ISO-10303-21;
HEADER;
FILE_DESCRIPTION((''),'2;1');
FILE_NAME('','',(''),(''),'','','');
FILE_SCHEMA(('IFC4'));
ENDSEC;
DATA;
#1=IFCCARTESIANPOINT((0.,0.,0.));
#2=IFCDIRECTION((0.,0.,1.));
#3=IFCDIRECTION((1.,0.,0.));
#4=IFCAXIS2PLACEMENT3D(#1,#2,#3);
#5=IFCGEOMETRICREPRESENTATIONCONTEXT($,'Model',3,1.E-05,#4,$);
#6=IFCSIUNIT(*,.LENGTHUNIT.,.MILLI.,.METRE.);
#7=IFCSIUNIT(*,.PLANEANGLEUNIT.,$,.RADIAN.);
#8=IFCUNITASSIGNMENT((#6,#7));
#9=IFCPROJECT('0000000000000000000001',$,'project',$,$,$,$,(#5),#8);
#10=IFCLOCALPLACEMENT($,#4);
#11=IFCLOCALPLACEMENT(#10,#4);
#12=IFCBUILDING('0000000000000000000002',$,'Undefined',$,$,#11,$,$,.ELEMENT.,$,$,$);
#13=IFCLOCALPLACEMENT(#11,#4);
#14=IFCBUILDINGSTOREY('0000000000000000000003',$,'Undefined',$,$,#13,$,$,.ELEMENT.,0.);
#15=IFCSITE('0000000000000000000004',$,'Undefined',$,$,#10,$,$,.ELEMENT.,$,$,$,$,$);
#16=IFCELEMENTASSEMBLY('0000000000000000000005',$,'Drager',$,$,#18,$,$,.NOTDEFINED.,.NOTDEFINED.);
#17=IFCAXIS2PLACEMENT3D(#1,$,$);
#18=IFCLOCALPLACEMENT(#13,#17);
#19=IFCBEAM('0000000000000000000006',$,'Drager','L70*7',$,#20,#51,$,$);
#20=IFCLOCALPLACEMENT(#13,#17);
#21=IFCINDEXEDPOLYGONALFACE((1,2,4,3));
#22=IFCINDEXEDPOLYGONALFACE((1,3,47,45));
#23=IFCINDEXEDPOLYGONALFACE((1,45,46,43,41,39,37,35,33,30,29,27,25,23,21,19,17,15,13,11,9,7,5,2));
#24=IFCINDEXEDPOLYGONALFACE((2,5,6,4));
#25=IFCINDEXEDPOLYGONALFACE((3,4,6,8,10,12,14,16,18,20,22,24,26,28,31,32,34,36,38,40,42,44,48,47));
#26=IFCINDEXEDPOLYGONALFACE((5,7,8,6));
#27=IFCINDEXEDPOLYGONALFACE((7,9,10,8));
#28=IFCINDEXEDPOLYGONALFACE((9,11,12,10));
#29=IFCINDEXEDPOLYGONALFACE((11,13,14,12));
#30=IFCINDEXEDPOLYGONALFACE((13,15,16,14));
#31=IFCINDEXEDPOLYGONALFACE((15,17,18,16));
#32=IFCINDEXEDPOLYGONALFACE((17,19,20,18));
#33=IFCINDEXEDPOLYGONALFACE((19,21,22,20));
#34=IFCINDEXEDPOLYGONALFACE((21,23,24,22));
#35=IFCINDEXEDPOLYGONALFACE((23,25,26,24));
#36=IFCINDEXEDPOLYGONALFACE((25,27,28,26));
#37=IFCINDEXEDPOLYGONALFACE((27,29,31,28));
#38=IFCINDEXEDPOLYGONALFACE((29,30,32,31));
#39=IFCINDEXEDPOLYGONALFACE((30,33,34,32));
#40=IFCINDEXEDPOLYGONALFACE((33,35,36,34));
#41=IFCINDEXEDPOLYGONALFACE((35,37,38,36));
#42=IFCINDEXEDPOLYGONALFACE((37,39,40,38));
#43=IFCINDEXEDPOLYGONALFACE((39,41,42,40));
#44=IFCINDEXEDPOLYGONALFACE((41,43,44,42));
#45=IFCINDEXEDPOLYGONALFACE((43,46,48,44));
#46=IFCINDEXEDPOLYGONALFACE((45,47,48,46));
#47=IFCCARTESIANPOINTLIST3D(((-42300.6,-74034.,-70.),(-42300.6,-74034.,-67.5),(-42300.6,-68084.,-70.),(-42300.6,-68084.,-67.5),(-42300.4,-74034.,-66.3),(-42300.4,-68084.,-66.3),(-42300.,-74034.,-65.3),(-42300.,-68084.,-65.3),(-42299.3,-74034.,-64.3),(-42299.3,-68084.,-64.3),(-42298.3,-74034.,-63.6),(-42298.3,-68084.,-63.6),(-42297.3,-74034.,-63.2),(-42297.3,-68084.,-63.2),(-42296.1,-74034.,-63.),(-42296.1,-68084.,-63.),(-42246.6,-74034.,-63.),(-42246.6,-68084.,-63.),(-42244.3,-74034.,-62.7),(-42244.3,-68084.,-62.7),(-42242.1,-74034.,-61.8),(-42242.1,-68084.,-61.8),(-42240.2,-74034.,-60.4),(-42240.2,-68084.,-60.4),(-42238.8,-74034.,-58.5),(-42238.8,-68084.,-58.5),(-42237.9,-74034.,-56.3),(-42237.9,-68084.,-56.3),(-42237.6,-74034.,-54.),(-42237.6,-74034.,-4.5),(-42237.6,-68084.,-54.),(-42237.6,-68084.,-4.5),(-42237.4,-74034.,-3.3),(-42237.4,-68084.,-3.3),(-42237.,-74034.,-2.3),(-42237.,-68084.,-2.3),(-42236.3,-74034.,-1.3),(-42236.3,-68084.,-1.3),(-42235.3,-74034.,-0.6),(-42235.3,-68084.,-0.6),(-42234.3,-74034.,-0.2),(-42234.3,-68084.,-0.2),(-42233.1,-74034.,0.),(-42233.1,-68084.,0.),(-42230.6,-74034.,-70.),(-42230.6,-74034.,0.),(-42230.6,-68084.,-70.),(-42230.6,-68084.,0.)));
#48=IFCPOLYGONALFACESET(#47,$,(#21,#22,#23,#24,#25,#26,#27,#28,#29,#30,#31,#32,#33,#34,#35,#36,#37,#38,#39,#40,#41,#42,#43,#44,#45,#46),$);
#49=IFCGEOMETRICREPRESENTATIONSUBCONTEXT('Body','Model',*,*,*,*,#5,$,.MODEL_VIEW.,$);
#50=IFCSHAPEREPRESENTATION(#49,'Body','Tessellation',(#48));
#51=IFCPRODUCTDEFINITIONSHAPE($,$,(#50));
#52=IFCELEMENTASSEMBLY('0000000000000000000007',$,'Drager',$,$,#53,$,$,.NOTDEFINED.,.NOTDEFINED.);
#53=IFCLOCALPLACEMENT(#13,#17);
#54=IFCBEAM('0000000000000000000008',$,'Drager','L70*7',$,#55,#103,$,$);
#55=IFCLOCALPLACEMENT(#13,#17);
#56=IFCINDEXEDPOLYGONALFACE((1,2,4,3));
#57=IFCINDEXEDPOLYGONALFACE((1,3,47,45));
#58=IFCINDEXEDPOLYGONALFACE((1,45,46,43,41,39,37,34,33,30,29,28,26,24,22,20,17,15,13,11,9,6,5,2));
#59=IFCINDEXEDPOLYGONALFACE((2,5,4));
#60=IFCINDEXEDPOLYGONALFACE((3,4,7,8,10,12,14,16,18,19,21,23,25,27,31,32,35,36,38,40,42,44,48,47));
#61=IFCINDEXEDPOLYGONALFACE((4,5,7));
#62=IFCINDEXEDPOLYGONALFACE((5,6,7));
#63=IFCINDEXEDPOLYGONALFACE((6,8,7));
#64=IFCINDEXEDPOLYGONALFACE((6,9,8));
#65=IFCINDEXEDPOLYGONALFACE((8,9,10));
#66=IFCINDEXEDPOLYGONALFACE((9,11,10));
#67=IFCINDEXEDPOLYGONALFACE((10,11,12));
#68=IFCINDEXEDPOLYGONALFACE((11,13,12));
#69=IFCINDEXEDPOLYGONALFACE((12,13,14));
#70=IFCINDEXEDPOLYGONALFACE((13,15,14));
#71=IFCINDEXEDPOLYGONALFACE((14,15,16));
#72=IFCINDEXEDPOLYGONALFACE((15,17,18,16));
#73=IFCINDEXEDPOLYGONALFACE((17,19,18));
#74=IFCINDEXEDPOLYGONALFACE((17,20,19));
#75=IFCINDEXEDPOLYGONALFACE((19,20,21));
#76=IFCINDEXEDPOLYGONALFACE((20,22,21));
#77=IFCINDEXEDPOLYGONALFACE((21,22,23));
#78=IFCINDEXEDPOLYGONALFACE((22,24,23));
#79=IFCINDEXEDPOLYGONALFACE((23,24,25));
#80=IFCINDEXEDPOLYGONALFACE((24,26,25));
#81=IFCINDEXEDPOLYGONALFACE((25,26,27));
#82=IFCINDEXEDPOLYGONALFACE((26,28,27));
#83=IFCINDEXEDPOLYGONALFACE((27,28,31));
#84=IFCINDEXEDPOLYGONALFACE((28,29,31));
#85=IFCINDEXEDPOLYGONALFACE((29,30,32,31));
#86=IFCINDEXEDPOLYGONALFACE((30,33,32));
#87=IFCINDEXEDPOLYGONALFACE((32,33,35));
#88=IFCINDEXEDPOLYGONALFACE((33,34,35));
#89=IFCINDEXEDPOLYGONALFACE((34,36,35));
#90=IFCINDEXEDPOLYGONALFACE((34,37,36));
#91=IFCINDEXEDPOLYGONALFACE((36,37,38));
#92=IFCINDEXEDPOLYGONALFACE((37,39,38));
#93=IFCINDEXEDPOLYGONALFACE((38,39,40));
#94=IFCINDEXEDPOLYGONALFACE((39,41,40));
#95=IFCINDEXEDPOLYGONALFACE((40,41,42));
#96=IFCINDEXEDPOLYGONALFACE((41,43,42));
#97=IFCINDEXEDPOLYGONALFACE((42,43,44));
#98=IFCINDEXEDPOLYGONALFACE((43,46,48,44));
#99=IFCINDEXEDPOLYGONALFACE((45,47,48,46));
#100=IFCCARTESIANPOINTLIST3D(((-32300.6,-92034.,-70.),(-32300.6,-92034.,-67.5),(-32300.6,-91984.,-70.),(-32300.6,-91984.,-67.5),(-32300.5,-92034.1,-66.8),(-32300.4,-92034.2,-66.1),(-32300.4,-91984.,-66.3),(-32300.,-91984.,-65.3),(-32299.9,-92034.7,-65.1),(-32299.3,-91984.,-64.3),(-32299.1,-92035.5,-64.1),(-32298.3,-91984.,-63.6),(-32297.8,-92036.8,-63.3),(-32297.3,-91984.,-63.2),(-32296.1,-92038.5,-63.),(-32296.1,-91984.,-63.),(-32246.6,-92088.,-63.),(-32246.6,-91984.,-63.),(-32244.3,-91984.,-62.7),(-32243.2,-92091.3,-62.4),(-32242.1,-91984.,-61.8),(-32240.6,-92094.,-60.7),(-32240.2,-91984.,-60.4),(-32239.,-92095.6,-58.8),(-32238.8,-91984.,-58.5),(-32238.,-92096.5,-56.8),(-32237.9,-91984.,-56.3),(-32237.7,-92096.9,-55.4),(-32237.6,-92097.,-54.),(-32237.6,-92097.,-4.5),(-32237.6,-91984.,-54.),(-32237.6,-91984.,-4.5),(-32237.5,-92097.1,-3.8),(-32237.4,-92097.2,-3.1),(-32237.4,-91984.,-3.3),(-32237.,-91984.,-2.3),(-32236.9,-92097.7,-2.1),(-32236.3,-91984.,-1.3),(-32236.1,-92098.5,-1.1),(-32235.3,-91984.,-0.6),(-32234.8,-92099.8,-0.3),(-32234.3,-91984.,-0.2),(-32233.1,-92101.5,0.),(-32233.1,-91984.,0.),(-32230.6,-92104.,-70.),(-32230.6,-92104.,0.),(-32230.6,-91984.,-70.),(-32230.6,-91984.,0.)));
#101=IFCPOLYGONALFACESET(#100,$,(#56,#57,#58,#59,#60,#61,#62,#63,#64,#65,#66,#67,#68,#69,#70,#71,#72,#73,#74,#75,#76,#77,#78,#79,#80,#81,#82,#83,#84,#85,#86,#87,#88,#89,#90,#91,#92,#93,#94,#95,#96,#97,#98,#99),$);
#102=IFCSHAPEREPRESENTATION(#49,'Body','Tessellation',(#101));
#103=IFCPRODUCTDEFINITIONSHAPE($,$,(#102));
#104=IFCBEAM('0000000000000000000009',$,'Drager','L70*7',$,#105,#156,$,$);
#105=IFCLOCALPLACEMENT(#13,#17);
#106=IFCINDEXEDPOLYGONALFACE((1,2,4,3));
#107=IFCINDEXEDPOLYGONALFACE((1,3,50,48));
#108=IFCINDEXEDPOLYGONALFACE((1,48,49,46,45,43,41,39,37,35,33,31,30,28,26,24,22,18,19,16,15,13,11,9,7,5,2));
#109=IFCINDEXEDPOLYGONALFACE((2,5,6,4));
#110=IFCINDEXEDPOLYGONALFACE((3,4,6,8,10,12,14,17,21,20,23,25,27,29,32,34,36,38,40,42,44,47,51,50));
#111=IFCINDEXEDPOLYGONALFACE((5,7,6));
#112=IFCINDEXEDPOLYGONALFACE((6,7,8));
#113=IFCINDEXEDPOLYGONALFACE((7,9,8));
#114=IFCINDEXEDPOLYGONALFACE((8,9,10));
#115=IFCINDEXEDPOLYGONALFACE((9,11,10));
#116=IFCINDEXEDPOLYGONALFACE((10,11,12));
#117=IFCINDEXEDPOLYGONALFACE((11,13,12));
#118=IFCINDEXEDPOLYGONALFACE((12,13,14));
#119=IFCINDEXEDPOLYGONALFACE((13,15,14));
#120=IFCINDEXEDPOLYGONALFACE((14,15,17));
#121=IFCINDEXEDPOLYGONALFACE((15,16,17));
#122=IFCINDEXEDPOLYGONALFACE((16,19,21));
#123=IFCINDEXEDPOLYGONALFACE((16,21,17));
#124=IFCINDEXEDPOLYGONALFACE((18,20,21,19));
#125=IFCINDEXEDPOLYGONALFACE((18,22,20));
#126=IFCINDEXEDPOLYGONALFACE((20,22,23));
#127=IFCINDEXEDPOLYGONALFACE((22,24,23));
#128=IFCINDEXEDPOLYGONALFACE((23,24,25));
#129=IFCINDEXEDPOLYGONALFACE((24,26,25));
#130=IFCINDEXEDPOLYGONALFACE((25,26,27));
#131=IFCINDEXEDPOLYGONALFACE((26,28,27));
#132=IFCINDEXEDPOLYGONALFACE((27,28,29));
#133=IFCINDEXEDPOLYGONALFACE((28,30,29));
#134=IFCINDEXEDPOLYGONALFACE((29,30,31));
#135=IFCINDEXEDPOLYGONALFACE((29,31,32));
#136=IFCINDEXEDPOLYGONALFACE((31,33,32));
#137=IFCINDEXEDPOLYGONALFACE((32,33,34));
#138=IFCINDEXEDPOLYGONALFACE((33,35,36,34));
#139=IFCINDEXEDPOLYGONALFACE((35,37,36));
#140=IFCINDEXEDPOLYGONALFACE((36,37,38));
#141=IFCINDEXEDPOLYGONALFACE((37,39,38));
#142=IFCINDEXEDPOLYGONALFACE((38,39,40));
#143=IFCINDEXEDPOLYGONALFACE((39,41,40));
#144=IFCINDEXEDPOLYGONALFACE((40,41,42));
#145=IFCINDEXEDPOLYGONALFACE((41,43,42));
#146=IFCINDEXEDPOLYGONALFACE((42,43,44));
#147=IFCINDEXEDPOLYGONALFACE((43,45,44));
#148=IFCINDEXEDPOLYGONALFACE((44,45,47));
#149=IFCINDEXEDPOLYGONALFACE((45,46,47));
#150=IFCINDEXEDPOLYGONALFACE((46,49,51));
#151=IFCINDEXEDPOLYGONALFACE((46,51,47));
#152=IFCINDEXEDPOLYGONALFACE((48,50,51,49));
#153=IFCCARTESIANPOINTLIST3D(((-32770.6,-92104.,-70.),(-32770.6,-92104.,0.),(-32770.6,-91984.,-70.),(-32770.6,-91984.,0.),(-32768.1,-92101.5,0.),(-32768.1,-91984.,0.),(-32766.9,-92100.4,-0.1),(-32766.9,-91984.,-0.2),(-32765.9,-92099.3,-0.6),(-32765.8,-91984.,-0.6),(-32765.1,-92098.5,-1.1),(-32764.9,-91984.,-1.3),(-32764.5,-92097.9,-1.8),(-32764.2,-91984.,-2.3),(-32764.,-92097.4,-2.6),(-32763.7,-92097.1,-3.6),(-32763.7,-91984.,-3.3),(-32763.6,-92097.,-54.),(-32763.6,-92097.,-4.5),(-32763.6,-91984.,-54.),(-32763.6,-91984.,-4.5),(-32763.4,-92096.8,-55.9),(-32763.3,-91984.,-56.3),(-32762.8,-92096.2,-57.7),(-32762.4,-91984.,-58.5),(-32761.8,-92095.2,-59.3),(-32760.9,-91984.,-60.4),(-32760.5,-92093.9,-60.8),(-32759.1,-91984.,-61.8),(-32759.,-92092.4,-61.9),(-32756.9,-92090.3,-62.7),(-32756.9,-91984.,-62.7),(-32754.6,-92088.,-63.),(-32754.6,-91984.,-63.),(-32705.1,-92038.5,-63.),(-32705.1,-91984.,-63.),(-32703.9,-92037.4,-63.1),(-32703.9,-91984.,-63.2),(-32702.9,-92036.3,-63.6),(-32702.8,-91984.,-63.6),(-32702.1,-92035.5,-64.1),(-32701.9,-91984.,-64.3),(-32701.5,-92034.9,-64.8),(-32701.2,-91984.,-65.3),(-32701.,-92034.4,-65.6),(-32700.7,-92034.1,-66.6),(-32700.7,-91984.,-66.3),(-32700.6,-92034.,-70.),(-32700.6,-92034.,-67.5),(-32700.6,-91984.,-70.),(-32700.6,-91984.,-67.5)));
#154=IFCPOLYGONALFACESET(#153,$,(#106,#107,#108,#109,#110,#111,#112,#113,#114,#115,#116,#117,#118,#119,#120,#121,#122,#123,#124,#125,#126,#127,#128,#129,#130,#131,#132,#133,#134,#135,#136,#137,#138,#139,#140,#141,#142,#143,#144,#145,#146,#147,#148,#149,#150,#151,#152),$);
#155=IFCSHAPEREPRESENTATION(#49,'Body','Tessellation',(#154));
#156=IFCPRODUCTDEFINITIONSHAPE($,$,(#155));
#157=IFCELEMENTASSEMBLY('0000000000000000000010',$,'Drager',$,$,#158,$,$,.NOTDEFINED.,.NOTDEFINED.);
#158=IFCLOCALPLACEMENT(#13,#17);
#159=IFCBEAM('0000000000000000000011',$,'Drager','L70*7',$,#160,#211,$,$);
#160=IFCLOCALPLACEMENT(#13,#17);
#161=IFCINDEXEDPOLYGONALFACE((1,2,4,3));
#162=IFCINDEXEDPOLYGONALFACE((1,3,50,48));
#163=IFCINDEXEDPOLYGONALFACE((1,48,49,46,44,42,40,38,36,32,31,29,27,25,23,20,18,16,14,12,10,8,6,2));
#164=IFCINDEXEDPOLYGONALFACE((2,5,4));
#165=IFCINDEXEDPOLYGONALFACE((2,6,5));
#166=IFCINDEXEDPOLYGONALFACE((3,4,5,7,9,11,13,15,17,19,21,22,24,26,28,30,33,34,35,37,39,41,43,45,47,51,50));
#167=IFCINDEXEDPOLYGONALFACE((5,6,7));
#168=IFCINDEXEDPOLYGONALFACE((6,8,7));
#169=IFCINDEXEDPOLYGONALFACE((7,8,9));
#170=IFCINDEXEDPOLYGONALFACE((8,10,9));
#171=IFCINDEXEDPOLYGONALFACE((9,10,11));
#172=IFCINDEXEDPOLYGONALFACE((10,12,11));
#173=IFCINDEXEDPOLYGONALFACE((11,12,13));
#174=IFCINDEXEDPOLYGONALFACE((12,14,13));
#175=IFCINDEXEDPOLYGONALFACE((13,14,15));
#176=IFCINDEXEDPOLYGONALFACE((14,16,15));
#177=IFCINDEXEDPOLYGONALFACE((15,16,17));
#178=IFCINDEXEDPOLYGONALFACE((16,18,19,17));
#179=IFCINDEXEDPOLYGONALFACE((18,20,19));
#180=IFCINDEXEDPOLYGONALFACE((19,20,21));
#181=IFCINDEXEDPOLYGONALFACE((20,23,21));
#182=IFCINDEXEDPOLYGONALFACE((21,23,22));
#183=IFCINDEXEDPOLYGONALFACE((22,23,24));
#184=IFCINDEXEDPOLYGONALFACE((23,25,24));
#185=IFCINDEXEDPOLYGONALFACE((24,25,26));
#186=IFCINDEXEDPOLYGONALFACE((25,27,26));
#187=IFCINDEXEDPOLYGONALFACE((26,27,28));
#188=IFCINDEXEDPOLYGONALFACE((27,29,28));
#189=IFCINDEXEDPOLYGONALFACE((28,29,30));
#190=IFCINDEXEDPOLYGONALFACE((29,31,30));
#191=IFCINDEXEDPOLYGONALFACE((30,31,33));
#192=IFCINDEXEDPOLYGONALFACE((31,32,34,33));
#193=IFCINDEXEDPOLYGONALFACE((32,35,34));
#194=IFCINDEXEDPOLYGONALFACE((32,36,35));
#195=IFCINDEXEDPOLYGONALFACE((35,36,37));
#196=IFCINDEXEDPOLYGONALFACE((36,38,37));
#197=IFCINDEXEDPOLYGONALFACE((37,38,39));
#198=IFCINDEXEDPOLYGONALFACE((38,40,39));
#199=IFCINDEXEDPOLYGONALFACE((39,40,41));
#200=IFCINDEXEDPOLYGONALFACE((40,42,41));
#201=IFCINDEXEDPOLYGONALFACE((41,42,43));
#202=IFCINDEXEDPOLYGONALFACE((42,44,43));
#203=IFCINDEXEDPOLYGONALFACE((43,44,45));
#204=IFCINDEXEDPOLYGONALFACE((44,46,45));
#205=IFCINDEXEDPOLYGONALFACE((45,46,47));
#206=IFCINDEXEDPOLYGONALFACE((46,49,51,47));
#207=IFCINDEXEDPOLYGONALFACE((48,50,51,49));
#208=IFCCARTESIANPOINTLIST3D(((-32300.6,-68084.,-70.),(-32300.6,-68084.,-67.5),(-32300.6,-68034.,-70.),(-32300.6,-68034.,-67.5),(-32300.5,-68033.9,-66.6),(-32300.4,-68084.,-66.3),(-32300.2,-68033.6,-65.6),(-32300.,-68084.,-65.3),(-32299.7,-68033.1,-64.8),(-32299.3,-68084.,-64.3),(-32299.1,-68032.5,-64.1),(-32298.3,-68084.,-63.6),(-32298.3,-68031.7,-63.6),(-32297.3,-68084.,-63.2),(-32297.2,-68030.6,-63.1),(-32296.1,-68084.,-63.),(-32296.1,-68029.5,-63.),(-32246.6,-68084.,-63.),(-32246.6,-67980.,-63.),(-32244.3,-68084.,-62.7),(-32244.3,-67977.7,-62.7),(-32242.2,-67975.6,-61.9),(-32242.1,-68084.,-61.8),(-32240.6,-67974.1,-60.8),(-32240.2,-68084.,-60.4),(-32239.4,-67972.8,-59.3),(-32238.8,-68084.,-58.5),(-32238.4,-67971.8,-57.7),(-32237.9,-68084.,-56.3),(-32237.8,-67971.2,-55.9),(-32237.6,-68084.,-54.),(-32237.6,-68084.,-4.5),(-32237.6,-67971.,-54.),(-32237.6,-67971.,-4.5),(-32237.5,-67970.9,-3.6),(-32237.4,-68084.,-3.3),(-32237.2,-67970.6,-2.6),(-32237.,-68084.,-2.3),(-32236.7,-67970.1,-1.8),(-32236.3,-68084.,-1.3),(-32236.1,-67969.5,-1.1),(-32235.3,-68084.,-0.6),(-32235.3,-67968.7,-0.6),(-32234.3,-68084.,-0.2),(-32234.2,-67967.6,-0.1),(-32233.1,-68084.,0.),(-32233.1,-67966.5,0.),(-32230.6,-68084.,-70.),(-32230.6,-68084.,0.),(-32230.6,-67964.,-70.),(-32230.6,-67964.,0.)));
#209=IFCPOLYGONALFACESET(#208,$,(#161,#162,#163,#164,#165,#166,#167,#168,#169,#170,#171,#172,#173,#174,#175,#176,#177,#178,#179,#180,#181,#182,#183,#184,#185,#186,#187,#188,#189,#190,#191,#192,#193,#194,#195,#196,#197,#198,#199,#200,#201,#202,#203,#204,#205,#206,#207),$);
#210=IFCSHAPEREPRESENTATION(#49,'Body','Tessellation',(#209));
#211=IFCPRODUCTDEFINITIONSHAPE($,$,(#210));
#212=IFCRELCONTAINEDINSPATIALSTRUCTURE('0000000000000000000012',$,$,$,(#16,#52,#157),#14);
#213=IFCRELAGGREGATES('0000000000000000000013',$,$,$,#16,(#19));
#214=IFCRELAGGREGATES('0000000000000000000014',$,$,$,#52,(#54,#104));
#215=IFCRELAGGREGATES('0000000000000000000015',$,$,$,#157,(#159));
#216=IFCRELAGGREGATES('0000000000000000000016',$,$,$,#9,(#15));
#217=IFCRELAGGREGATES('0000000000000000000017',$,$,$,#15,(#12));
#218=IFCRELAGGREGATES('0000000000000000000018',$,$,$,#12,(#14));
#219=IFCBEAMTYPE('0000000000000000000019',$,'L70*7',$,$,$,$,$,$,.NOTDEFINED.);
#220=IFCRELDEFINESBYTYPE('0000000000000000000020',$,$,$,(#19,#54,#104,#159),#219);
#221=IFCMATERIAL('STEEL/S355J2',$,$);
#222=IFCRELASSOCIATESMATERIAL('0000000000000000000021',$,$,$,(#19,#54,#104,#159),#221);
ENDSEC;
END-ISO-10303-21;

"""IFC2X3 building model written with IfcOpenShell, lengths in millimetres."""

from ifc_helpers import new_model, si_unit, frame, origin_with_axes, origin_2d_with_axis, place, context, subcontext, project, spatial, l_section, extrude, clip, halfspace, material, type_object, element, aggregate, save


model = new_model("IFC2X3")

# Units and contexts
model_context = context("Model", 3, precision=1e-05, world=origin_with_axes())
body_context = subcontext(model_context, "Body", "Model", "MODEL_VIEW")
ifc_project = project(units=[si_unit("LENGTHUNIT", "METRE", prefix="MILLI"), si_unit("PLANEANGLEUNIT", "RADIAN")], contexts=[model_context])

# Site, building, storey
site_placement = place(None, origin_with_axes())
site = spatial("IfcSite", under=ifc_project, at=site_placement, Name="Undefined", CompositionType="ELEMENT")
building_placement = place(site_placement, origin_with_axes())
building = spatial("IfcBuilding", under=site, at=building_placement, Name="Undefined", CompositionType="ELEMENT")
storey_placement = place(building_placement, origin_with_axes())
storey = spatial("IfcBuildingStorey", under=building, at=storey_placement, Name="Undefined", CompositionType="ELEMENT", Elevation=0.0)

# Element assembly, beam
assembly_1_placement = place(storey_placement, origin_with_axes())
assembly_1 = element("IfcElementAssembly", 1, at=assembly_1_placement, inside=storey, Name="Drager", AssemblyPlace="NOTDEFINED", PredefinedType="NOTDEFINED")
ifc_material = material(Name="STEEL/S355J2")
beam_type = type_object("IfcBeamType", Name="L70*7", PredefinedType="NOTDEFINED")
beam_1_placement = place(assembly_1_placement, frame((-42265.6, -68084.0, -35.0), z_axis=(0.0, 0.0, 1.0), x_axis=(0.0, -1.0, 0.0)))
beam_1 = element("IfcBeam", 2, at=beam_1_placement, type_object=beam_type, material=ifc_material, Name="Drager", Description="L70*7", context=body_context, shape_type="SweptSolid", body=[
    extrude(l_section(Depth=70.0, Width=70.0, Thickness=7.0, FilletRadius=9.0, EdgeRadius=4.5, at=origin_2d_with_axis()), frame((5950.0, 0.0, 0.0), z_axis=(-1.0, 0.0, 0.0), x_axis=(0.0, -1.0, 0.0)), (0.0, 0.0, 1.0), 5950.0),
])
aggregate(assembly_1, [beam_1])

# Element assemblies, beams
assembly_2_placement = place(storey_placement, origin_with_axes())
assembly_2 = element("IfcElementAssembly", 3, at=assembly_2_placement, inside=storey, Name="Drager", AssemblyPlace="NOTDEFINED", PredefinedType="NOTDEFINED")
beam_2_placement = place(assembly_2_placement, frame((-32265.6, -91984.0, -35.0), z_axis=(0.0, 0.0, 1.0), x_axis=(0.0, -1.0, 0.0)))
beam_2 = element("IfcBeam", 4, at=beam_2_placement, type_object=beam_type, material=ifc_material, Name="Drager", Description="L70*7", context=body_context, shape_type="Clipping", body=[
    clip(extrude(l_section(Depth=70.0, Width=70.0, Thickness=7.0, FilletRadius=9.0, EdgeRadius=4.5, at=origin_2d_with_axis()), frame((120.3, 0.0, 0.0), z_axis=(-1.0, 0.0, 0.0), x_axis=(0.0, -1.0, 0.0)), (0.0, 0.0, 1.0), 120.3), halfspace(frame((50.0, -35.0, 35.0), z_axis=(0.707107, -0.707107, 0.0), x_axis=(0.0, 0.0, 1.0)), False)),
])
beam_3_placement = place(assembly_2_placement, frame((-32735.6, -92034.0, -35.0), z_axis=(0.0, 0.0, 1.0), x_axis=(0.0, 1.0, 0.0)))
beam_3 = element("IfcBeam", 5, at=beam_3_placement, type_object=beam_type, material=ifc_material, Name="Drager", Description="L70*7", context=body_context, shape_type="Clipping", body=[
    clip(extrude(l_section(Depth=70.0, Width=70.0, Thickness=7.0, FilletRadius=9.0, EdgeRadius=4.5, at=origin_2d_with_axis()), frame((50.0, 0.0, 0.0), z_axis=(-1.0, 0.0, 0.0), x_axis=(0.0, -1.0, 0.0)), (0.0, 0.0, 1.0), 120.3), halfspace(frame((0.0, -35.0, 35.0), z_axis=(-0.707107, -0.707107, 0.0), x_axis=(-0.707107, 0.707107, 0.0)), False)),
])
assembly_3_placement = place(storey_placement, origin_with_axes())
assembly_3 = element("IfcElementAssembly", 6, at=assembly_3_placement, inside=storey, Name="Drager", AssemblyPlace="NOTDEFINED", PredefinedType="NOTDEFINED")
beam_4_placement = place(assembly_3_placement, frame((-32265.6, -68034.0, -35.0), z_axis=(0.0, 0.0, 1.0), x_axis=(0.0, -1.0, 0.0)))
beam_4 = element("IfcBeam", 7, at=beam_4_placement, type_object=beam_type, material=ifc_material, Name="Drager", Description="L70*7", context=body_context, shape_type="Clipping", body=[
    clip(extrude(l_section(Depth=70.0, Width=70.0, Thickness=7.0, FilletRadius=9.0, EdgeRadius=4.5, at=origin_2d_with_axis()), frame((50.0, 0.0, 0.0), z_axis=(-1.0, 0.0, 0.0), x_axis=(0.0, -1.0, 0.0)), (0.0, 0.0, 1.0), 120.3), halfspace(frame((0.0, -35.0, 35.0), z_axis=(-0.707107, -0.707107, 0.0), x_axis=(-0.707107, 0.707107, 0.0)), False)),
])

aggregate(assembly_2, [beam_2, beam_3])

aggregate(assembly_3, [beam_4])

save(model, "model.ifc")
